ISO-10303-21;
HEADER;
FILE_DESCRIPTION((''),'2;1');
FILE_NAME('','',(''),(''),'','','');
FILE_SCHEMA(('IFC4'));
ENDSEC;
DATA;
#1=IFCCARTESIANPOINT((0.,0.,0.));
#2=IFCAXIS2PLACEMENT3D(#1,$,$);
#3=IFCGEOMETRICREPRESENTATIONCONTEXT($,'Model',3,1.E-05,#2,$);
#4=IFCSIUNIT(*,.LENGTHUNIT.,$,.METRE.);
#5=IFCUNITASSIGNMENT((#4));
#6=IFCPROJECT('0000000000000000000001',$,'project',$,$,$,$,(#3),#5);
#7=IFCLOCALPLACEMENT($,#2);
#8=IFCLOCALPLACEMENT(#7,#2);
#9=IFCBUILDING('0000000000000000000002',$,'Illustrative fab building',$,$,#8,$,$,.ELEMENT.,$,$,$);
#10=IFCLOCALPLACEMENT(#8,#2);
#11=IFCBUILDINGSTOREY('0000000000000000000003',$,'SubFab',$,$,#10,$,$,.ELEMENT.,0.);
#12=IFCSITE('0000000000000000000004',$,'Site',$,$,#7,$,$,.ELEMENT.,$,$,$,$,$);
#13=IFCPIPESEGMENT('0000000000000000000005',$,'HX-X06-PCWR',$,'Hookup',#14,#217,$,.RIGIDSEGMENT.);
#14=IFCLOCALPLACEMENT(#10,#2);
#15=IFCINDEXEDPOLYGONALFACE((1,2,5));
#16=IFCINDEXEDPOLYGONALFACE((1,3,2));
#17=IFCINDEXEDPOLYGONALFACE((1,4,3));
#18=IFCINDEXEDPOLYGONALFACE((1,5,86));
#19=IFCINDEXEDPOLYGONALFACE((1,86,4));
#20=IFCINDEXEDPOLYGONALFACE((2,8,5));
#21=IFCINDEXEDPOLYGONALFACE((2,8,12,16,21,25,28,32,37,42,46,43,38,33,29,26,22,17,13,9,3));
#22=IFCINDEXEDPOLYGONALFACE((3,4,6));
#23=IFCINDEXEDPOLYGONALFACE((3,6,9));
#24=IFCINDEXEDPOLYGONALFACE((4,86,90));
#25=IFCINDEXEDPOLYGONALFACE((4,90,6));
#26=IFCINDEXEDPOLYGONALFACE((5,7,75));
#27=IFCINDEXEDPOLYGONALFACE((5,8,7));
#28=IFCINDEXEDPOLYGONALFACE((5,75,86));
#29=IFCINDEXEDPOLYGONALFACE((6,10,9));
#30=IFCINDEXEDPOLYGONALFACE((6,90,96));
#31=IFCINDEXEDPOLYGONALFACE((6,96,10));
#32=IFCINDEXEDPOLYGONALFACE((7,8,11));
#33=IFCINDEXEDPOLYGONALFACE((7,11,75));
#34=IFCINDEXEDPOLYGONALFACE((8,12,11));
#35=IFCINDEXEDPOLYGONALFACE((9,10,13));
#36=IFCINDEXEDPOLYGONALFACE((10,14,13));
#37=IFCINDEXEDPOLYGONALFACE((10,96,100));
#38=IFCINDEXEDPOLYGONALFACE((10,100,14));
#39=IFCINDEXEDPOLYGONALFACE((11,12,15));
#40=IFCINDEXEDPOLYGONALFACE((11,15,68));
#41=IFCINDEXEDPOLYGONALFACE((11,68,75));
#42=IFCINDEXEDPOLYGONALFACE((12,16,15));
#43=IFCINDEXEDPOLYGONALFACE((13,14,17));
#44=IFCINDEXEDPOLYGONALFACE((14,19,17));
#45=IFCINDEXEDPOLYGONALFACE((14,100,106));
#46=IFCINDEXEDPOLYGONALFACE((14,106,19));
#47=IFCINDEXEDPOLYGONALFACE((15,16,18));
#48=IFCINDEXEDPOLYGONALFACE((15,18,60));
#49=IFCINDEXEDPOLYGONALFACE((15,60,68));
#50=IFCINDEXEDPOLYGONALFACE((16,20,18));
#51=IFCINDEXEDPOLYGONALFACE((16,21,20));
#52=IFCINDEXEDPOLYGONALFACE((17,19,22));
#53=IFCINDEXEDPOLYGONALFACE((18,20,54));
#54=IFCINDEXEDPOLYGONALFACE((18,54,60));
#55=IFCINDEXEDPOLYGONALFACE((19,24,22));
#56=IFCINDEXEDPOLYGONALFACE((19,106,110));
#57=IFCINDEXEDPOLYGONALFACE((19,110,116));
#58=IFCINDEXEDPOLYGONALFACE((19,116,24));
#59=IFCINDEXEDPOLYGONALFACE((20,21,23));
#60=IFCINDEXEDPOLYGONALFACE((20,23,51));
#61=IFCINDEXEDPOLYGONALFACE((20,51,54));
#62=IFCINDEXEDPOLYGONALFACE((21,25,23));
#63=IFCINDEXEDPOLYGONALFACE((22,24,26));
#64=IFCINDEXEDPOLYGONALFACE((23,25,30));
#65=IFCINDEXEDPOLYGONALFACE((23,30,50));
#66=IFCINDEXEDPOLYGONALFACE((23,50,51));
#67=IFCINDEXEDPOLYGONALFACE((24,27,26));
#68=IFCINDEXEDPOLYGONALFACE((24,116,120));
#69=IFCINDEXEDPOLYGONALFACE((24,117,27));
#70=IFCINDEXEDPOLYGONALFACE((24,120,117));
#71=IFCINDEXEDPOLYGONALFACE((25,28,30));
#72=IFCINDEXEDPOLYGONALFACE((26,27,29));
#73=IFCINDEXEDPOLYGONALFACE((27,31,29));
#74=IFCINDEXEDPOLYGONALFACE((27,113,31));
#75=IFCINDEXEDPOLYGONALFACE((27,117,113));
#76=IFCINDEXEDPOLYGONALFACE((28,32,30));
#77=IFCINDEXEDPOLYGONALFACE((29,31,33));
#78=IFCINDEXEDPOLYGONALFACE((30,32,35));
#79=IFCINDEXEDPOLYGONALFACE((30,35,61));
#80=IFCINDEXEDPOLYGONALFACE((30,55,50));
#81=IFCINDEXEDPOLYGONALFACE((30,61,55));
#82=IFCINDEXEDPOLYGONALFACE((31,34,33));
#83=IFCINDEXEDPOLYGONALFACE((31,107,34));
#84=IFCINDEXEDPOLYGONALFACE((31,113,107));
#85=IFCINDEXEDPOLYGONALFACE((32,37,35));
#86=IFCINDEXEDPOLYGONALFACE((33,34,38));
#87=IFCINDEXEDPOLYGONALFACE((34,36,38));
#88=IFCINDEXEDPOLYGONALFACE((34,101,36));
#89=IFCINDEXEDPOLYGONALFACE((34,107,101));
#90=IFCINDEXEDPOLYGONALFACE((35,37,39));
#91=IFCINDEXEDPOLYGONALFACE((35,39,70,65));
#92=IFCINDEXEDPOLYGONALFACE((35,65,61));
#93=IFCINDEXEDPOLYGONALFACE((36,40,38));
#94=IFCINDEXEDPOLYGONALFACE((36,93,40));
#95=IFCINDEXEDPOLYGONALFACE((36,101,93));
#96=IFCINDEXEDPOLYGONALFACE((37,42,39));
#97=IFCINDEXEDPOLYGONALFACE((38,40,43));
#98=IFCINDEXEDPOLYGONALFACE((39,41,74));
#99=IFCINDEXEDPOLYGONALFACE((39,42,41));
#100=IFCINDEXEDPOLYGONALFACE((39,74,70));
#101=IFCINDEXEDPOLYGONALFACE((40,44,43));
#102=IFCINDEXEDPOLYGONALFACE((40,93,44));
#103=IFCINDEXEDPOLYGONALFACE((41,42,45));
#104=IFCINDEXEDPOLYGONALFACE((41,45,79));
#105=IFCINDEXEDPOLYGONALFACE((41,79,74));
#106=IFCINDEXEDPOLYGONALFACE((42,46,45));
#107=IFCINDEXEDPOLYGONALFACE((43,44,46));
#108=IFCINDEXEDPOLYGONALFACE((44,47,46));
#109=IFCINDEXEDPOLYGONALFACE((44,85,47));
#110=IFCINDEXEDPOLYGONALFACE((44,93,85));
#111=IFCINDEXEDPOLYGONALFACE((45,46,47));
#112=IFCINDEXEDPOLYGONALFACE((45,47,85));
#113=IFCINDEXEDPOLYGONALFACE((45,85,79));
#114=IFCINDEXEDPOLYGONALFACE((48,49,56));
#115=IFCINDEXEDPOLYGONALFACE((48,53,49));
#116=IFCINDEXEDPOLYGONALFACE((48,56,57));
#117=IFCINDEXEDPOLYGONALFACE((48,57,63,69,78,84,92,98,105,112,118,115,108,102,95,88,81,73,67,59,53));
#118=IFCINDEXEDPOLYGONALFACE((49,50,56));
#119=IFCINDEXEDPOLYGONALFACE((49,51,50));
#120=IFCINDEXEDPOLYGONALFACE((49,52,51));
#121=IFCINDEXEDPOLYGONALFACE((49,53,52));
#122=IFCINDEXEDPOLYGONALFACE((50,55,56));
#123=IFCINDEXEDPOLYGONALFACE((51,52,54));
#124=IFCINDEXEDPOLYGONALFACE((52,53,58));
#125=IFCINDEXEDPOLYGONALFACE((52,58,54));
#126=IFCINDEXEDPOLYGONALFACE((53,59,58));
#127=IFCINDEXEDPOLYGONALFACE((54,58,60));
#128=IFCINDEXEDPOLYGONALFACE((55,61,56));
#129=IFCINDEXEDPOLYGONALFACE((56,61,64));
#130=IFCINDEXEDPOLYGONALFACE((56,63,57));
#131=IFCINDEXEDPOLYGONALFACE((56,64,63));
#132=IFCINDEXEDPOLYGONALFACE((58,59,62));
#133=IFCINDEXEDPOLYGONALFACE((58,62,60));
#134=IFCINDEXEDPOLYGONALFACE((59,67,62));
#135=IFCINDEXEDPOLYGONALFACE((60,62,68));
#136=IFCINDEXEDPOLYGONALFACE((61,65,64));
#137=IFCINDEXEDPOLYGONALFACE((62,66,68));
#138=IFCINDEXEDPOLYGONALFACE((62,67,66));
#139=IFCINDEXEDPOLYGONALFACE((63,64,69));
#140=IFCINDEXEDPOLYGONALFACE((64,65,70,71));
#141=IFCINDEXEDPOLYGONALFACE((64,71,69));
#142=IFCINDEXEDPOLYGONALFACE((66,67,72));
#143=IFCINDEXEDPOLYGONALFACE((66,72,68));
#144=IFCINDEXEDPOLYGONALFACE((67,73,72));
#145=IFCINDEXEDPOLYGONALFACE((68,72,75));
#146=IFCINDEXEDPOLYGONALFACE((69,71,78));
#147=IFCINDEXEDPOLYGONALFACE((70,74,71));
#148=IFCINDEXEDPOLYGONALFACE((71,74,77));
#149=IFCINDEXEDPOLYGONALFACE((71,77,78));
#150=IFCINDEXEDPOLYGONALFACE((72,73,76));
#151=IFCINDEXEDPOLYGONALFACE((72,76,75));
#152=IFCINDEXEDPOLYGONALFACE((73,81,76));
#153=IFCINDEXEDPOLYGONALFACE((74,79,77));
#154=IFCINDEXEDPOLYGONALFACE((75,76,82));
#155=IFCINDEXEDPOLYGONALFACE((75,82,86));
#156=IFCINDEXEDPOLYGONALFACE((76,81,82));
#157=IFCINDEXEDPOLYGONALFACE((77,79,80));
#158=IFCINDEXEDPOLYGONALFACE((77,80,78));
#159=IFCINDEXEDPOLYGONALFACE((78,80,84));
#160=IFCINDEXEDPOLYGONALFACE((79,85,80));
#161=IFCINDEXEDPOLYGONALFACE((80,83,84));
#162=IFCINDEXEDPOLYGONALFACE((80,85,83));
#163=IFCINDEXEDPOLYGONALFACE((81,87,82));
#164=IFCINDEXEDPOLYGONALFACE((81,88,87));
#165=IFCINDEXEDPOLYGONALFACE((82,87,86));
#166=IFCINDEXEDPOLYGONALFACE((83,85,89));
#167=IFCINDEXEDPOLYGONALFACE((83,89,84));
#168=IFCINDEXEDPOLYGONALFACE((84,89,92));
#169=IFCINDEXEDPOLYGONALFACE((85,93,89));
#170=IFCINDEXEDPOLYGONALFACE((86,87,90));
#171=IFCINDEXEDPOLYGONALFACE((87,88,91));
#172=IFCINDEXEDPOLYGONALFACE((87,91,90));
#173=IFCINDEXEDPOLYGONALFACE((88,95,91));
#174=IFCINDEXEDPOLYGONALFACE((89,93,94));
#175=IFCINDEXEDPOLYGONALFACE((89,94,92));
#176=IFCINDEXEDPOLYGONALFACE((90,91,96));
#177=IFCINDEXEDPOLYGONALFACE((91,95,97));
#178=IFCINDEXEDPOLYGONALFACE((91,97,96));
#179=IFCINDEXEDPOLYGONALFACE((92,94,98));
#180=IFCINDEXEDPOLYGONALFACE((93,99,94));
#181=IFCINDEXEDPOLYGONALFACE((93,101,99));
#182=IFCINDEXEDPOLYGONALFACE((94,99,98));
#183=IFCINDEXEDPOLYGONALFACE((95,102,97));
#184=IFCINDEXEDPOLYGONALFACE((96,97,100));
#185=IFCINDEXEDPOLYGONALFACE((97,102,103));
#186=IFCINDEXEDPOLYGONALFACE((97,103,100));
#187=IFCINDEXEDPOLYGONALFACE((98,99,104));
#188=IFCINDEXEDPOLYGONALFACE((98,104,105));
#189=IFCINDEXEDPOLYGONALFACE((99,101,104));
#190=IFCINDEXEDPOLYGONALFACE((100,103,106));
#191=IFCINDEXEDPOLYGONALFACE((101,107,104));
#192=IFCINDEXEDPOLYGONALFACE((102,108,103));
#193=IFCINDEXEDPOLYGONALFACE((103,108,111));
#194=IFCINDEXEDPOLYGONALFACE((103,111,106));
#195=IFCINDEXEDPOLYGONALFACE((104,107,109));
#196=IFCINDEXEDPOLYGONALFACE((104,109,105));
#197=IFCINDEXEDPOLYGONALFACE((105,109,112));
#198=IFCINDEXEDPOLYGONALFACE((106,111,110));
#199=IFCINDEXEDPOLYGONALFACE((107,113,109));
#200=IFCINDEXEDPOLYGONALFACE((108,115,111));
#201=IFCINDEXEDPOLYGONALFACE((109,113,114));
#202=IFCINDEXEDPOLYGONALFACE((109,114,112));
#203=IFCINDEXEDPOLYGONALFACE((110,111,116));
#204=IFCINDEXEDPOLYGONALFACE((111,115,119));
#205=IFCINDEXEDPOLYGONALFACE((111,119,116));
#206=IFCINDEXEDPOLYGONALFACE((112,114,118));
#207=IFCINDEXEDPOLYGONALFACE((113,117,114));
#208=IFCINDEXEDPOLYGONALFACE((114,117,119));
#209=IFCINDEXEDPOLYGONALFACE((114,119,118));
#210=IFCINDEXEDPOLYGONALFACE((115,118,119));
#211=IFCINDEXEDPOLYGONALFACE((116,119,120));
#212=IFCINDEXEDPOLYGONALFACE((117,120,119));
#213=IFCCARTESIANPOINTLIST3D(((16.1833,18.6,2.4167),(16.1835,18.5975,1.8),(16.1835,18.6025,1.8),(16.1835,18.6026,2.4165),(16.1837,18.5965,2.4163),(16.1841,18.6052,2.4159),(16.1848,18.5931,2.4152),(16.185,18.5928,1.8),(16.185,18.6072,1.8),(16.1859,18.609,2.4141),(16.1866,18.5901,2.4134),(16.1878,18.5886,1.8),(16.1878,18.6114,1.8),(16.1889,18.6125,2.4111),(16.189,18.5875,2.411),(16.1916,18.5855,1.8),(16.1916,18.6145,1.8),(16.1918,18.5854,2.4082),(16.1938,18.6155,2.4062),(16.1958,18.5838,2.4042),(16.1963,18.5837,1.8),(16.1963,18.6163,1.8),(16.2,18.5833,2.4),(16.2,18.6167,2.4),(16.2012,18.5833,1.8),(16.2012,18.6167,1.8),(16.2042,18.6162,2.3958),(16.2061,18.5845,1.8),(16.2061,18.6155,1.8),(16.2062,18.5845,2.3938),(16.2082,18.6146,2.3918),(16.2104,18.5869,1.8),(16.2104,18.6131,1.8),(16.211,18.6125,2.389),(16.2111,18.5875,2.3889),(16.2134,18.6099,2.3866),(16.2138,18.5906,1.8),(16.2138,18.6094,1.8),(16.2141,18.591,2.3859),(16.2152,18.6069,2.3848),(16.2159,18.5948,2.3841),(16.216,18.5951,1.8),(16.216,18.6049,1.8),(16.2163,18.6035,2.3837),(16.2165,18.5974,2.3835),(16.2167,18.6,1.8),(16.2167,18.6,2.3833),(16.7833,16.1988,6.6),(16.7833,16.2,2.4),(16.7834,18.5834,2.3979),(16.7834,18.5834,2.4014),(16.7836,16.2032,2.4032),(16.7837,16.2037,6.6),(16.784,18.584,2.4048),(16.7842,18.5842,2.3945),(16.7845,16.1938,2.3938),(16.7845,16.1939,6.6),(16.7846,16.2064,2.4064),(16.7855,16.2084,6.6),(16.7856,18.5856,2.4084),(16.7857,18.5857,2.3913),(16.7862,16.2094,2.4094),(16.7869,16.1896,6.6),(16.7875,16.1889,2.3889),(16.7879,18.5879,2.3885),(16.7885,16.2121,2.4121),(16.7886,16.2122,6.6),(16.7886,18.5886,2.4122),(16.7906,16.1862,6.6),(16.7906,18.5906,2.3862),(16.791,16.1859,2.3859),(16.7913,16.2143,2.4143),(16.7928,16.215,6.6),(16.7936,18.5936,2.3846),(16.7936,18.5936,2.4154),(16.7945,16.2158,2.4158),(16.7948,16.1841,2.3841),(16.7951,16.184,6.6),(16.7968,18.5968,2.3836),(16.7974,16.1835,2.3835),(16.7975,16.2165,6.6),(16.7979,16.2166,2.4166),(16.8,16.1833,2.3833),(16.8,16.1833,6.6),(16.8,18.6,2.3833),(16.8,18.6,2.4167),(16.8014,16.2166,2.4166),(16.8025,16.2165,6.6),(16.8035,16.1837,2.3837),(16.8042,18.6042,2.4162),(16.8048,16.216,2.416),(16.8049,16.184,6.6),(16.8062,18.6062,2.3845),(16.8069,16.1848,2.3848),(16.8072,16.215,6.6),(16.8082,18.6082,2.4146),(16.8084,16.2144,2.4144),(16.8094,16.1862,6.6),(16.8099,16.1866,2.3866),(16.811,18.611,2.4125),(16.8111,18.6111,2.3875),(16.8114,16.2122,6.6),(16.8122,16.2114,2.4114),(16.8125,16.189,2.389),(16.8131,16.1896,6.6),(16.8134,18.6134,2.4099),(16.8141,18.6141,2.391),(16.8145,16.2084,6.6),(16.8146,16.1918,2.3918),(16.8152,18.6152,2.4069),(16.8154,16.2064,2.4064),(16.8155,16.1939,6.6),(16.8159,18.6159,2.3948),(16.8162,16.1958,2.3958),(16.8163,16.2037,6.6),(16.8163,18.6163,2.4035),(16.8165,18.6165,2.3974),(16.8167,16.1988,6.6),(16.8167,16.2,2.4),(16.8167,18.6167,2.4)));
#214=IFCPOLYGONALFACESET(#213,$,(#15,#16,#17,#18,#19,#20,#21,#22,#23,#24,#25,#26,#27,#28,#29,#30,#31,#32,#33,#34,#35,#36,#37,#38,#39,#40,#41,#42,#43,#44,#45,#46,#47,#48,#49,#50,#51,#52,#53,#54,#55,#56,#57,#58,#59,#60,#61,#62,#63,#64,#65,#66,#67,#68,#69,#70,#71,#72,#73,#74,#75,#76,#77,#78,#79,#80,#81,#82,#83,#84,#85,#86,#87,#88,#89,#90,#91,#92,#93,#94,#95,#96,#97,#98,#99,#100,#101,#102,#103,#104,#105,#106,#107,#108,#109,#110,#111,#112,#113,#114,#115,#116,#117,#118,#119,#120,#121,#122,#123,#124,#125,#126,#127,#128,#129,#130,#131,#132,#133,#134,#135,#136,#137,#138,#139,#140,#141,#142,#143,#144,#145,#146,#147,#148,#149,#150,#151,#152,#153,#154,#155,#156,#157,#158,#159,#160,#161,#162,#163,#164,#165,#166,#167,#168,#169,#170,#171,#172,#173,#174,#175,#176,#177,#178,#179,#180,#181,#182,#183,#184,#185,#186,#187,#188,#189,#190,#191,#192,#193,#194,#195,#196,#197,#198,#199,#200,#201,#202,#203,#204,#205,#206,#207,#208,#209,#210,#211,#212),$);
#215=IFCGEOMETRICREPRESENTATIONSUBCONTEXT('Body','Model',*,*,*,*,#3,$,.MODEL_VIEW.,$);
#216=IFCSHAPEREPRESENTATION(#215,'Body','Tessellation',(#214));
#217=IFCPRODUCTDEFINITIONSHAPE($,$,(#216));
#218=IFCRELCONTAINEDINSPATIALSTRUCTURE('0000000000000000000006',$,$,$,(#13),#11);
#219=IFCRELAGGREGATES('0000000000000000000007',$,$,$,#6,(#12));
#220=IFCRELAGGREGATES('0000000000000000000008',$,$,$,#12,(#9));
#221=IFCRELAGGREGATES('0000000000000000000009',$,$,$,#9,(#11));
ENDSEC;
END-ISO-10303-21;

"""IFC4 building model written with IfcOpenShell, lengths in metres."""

from ifc_helpers import new_model, entity, si_unit, origin, place, context, subcontext, project, spatial, element, save


model = new_model("IFC4")

# Units and contexts
model_context = context("Model", 3, precision=1e-05, world=origin())
body_context = subcontext(model_context, "Body", "Model", "MODEL_VIEW")
ifc_project = project(units=[si_unit("LENGTHUNIT", "METRE")], contexts=[model_context])

# Site, building, storey
site_placement = place(None, origin())
site = spatial("IfcSite", under=ifc_project, at=site_placement, Name="Site", CompositionType="ELEMENT")
building_placement = place(site_placement, origin())
building = spatial("IfcBuilding", under=site, at=building_placement, Name="Illustrative fab building", CompositionType="ELEMENT")
storey_placement = place(building_placement, origin())
storey = spatial("IfcBuildingStorey", under=building, at=storey_placement, Name="SubFab", CompositionType="ELEMENT", Elevation=0.0)

# Pipe segment
pipe_segment_1_placement = place(storey_placement, origin())
element("IfcPipeSegment", 1, at=pipe_segment_1_placement, inside=storey, Name="HX-X06-PCWR", ObjectType="Hookup", PredefinedType="RIGIDSEGMENT", context=body_context, shape_type="AdvancedSweptSolid", body=[
    entity("IfcSweptDiskSolid", entity("IfcPolyline", [entity("IfcCartesianPoint", [16.2, 18.6, 1.8]), entity("IfcCartesianPoint", [16.2, 18.6, 2.4]), entity("IfcCartesianPoint", [16.8, 18.6, 2.4]), entity("IfcCartesianPoint", [16.8, 16.2, 2.4]), entity("IfcCartesianPoint", [16.8, 16.2, 6.6])]), 0.0167),
])

save(model, "model.ifc")
